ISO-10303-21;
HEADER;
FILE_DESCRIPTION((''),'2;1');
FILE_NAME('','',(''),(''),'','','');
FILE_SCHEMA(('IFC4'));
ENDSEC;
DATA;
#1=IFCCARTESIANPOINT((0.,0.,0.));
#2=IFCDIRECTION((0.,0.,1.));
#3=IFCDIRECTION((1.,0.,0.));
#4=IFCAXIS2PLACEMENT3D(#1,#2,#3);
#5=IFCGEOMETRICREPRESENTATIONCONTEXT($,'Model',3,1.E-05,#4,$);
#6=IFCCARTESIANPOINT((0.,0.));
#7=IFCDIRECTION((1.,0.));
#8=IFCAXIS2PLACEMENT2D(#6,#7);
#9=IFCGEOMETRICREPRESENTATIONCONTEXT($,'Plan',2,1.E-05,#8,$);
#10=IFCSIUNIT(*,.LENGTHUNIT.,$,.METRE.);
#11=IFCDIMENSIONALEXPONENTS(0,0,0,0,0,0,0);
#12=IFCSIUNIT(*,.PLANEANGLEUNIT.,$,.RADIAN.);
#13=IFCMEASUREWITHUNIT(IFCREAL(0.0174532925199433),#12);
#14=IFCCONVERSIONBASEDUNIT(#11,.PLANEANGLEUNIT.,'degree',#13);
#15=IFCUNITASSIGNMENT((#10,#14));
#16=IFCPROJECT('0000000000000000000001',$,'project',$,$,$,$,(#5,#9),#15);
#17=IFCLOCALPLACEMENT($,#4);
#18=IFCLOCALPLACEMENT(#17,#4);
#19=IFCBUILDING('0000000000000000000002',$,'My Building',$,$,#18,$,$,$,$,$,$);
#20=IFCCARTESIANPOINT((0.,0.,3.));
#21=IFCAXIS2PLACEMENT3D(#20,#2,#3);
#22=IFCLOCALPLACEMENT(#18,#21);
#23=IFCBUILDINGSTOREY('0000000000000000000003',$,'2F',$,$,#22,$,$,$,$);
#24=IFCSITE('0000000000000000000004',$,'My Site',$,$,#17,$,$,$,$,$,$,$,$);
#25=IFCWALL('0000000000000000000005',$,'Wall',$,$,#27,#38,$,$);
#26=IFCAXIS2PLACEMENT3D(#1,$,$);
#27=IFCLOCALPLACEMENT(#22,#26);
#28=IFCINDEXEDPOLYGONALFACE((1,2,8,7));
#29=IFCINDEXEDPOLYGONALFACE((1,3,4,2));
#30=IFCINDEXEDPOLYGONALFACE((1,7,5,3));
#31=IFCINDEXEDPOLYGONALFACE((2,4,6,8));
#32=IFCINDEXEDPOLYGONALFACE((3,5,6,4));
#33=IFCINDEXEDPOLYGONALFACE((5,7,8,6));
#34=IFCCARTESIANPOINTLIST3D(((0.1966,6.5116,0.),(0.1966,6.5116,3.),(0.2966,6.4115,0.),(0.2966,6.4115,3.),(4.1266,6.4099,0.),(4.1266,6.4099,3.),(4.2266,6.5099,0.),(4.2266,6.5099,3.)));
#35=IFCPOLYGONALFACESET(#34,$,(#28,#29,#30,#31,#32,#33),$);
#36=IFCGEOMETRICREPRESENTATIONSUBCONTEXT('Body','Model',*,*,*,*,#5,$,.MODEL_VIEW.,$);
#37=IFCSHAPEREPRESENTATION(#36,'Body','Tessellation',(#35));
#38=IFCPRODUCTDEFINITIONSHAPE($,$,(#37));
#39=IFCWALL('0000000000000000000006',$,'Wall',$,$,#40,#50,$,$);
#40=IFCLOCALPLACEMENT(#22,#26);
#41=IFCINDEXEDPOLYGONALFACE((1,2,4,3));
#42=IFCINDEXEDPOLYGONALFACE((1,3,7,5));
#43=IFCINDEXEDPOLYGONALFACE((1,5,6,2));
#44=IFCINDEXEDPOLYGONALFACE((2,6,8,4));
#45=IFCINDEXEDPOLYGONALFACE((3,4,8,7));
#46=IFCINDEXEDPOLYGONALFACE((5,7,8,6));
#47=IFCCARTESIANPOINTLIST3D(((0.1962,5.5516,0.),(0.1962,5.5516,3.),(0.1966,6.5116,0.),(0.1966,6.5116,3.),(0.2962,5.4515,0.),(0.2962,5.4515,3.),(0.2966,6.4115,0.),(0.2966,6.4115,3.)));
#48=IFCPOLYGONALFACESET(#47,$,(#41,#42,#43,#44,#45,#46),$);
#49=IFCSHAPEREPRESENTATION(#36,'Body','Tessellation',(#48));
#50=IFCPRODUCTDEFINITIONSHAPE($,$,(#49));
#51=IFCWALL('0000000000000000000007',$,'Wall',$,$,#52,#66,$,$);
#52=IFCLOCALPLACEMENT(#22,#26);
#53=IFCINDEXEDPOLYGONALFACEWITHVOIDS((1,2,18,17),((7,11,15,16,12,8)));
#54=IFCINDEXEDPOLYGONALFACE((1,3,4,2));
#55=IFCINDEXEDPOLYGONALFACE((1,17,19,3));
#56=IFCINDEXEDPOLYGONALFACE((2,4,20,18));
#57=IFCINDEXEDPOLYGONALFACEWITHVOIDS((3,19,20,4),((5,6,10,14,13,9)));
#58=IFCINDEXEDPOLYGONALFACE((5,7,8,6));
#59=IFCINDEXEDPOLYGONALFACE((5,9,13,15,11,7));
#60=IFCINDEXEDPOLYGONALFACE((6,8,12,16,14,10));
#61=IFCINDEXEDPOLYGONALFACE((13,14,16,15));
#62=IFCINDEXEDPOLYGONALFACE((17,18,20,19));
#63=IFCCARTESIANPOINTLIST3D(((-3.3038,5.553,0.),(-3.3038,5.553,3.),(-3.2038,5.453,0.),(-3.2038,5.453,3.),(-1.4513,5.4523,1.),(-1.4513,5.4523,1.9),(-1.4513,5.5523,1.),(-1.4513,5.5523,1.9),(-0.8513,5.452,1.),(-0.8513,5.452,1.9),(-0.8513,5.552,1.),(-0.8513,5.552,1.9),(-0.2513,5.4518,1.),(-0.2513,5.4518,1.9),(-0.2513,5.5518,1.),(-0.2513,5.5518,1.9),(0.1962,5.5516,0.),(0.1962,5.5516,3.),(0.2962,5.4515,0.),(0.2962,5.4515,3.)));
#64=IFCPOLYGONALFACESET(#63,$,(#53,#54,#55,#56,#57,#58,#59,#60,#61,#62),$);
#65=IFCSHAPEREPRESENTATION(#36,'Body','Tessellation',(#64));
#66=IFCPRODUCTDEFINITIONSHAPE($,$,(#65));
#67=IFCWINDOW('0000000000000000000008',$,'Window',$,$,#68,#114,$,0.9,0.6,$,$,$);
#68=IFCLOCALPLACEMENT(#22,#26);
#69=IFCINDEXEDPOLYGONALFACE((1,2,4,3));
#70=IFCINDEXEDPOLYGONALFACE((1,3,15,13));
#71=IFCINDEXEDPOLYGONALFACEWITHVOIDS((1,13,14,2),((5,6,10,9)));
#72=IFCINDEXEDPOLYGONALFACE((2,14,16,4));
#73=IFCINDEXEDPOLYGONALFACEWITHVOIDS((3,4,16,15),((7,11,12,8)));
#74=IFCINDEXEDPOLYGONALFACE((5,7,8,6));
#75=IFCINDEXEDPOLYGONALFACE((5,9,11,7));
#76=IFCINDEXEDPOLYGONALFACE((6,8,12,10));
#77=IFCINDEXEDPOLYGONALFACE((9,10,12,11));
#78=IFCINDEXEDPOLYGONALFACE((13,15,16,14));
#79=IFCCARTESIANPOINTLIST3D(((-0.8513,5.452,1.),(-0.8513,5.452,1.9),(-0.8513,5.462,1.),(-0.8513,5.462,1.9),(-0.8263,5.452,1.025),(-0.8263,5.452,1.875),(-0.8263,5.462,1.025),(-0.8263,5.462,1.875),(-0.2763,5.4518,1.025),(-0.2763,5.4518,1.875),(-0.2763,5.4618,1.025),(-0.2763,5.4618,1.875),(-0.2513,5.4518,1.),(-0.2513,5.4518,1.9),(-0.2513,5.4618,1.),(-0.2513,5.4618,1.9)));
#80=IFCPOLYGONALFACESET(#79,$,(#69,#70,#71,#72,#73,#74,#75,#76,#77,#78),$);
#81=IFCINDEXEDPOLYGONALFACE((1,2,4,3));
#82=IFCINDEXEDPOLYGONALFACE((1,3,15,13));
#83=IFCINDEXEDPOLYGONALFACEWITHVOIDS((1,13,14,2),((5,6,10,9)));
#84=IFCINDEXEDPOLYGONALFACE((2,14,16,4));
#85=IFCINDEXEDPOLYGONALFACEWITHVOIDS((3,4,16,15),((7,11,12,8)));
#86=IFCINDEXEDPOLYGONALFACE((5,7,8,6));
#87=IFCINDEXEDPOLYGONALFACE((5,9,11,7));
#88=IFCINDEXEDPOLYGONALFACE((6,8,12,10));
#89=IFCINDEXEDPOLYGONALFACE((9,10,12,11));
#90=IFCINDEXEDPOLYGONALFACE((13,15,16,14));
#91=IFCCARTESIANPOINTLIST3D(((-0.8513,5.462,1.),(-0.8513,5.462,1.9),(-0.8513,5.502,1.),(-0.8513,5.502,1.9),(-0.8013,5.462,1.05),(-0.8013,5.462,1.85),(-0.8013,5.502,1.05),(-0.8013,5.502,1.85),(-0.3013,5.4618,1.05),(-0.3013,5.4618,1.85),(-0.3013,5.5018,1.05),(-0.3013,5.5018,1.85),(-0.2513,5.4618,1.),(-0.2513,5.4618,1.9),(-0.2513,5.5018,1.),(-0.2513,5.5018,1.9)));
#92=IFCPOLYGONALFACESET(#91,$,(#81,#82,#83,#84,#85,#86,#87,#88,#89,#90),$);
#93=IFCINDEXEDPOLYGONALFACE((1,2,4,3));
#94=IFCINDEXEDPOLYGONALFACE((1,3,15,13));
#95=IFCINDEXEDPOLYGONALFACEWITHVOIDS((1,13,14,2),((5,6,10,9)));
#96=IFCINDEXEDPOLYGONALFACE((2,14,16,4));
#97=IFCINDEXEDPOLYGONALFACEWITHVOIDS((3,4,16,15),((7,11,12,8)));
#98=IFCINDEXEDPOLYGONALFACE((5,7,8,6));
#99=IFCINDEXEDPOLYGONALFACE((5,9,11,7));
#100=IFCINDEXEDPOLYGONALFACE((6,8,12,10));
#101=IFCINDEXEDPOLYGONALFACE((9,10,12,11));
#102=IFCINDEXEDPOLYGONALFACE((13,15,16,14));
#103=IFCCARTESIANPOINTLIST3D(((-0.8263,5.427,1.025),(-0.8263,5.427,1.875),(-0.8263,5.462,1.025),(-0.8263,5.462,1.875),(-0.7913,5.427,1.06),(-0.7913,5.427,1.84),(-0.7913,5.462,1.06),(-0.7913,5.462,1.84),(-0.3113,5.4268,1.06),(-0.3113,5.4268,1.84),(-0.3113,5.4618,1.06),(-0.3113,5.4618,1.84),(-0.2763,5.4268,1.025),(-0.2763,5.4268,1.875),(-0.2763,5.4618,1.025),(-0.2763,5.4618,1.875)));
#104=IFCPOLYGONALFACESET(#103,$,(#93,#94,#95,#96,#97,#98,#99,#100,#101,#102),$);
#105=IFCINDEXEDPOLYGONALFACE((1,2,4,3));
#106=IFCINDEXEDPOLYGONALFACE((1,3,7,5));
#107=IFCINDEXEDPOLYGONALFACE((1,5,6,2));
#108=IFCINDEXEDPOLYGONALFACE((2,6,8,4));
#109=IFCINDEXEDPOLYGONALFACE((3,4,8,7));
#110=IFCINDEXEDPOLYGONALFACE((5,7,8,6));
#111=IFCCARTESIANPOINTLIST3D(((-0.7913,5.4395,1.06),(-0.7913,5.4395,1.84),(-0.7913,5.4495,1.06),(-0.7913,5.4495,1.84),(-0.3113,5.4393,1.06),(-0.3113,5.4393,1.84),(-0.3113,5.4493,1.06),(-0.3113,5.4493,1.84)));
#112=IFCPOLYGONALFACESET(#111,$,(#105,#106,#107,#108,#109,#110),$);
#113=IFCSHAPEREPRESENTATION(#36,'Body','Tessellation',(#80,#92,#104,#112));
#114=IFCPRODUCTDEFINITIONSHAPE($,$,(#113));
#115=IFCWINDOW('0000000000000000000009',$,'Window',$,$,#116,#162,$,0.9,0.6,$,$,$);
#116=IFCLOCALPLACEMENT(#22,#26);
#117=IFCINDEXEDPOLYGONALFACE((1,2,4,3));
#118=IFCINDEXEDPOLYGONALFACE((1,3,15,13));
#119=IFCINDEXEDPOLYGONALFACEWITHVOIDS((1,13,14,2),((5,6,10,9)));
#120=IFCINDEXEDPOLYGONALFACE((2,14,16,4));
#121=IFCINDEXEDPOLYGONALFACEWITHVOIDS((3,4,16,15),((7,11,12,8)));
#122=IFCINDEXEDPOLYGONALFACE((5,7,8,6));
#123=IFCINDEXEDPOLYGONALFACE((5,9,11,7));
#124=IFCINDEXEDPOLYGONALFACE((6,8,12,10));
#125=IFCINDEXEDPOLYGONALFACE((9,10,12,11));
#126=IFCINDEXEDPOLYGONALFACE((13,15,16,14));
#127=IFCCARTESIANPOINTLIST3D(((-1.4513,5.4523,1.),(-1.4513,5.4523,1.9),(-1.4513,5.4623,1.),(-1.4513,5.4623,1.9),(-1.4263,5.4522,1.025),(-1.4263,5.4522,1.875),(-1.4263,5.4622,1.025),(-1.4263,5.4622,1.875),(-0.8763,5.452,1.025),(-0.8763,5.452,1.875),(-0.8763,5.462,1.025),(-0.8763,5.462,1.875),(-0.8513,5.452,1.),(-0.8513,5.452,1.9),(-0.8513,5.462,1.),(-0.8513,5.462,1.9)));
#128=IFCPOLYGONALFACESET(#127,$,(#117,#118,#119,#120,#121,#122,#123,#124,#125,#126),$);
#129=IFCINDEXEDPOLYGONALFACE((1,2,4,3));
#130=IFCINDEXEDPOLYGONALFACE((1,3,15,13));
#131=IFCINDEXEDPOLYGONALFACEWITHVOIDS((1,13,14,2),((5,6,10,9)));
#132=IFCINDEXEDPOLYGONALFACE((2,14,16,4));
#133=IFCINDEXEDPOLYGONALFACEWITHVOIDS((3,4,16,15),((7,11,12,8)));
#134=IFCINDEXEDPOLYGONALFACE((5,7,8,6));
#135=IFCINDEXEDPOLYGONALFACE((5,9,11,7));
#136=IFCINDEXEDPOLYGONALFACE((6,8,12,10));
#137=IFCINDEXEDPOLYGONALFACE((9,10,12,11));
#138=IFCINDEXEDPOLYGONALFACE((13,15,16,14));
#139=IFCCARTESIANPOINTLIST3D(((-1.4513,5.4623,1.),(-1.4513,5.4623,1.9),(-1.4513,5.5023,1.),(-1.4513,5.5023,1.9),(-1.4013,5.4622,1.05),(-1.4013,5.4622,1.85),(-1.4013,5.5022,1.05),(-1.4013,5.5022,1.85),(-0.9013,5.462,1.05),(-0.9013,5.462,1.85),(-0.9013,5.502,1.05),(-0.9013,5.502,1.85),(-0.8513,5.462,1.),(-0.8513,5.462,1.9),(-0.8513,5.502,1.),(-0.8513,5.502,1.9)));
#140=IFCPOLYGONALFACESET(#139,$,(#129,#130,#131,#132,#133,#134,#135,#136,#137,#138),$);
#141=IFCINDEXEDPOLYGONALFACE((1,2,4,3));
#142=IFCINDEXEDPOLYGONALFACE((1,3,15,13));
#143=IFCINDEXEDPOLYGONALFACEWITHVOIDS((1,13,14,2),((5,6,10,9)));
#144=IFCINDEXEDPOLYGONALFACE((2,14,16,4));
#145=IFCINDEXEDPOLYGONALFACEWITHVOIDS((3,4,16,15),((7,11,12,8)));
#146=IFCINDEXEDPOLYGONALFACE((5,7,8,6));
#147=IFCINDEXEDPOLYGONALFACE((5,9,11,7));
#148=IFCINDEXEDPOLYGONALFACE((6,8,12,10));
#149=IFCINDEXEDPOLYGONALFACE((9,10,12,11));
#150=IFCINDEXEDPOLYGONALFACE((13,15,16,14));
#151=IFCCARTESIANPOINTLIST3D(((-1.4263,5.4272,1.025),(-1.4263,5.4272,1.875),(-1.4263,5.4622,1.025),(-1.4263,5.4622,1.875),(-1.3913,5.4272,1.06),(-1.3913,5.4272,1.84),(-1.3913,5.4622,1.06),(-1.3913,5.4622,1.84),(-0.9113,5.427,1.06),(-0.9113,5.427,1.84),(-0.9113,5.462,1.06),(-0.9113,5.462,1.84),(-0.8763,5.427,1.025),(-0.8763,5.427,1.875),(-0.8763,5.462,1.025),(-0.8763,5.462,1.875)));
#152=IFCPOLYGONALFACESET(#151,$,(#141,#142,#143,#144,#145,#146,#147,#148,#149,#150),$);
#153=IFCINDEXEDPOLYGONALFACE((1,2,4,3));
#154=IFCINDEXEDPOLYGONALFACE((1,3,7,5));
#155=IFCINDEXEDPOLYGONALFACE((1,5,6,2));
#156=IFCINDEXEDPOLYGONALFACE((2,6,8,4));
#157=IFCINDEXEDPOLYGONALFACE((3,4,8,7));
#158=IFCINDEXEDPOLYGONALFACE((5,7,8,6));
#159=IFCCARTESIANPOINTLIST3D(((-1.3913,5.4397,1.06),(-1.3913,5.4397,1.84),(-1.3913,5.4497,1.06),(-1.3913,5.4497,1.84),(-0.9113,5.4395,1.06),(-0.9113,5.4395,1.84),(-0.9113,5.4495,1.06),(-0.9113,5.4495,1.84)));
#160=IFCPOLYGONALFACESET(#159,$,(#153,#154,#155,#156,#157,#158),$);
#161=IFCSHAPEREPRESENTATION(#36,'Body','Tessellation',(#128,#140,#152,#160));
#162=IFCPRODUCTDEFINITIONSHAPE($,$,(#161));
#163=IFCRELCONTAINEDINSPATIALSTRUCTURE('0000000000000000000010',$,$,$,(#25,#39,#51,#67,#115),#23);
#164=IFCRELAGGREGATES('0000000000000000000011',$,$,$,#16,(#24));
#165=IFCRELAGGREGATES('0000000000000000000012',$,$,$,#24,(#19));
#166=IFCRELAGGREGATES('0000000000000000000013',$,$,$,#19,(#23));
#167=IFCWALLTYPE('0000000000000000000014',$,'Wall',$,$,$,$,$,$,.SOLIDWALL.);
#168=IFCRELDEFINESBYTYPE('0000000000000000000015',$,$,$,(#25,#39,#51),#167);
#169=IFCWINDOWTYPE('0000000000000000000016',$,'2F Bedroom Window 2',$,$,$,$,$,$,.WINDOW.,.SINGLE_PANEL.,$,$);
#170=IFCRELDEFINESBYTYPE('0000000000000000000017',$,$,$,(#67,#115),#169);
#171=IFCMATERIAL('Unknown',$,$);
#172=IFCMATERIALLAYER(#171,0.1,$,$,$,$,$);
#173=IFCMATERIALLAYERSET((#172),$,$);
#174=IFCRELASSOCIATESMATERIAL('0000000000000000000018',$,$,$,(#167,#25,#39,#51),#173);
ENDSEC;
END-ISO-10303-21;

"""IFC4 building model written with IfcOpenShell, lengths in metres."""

from ifc_helpers import new_model, entity, si_unit, converted_unit, frame, origin_with_axes, origin_2d_with_axis, place, context, subcontext, project, spatial, line, indexed_curve, outline, extrude, shape, source, transform, mapped, material, layer, layer_set, layer_usage, type_object, type_shapes, element, fill, save


model = new_model("IFC4")

# Units and contexts
model_context = context("Model", 3, precision=1e-05, world=origin_with_axes())
plan_context = context("Plan", 2, precision=1e-05, world=origin_2d_with_axis())
body_context_1 = subcontext(model_context, "Body", "Model", "MODEL_VIEW")
body_context_2 = subcontext(plan_context, "Body", "Plan", "PLAN_VIEW")
ifc_project = project(units=[si_unit("LENGTHUNIT", "METRE"), converted_unit("PLANEANGLEUNIT", "degree", entity("IfcReal", 0.0174532925199433), si_unit("PLANEANGLEUNIT", "RADIAN"), dimensions=[0, 0, 0, 0, 0, 0, 0])], contexts=[model_context, plan_context])

# Site, building, storey
site_placement = place(None, origin_with_axes())
site = spatial("IfcSite", under=ifc_project, at=site_placement, Name="My Site")
building_placement = place(site_placement, origin_with_axes())
building = spatial("IfcBuilding", under=site, at=building_placement, Name="My Building")
storey_placement = place(building_placement, frame((0.0, 0.0, 3.0), z_axis=(0.0, 0.0, 1.0), x_axis=(1.0, 0.0, 0.0)))
storey = spatial("IfcBuildingStorey", under=building, at=storey_placement, Name="2F")

# Shared definitions
ifc_material = material(Name="Unknown")

# Walls
ifc_layer = layer(ifc_material, 0.1)
ifc_layer_set = layer_set([ifc_layer])
ifc_layer_usage_1 = layer_usage(ifc_layer_set, "AXIS2", "POSITIVE", 0.0)
wall_type = type_object("IfcWallType", Name="Wall", PredefinedType="SOLIDWALL", material=ifc_layer_set)
wall_1_placement = place(storey_placement, frame((4.2266, 6.5099, 0.0), z_axis=(0.0, 0.0, 1.0), x_axis=(-1.0, 0.000415, 0.0)))
element("IfcWall", 1, at=wall_1_placement, inside=storey, type_object=wall_type, material=ifc_layer_usage_1, Name="Wall", context=body_context_1, shape_type="SweptSolid", body=[
    extrude(outline(indexed_curve([(0.0, 0.0), (0.1, 0.1), (3.93, 0.1), (4.03, 0.0)], segments=[line(1, 2, 3, 4, 1)])), origin_with_axes(), (0.0, 0.0, 1.0), 3.0),
])
ifc_layer_usage_2 = layer_usage(ifc_layer_set, "AXIS2", "POSITIVE", 0.0)
wall_2_placement = place(storey_placement, frame((0.1966, 6.5116, 0.0), z_axis=(0.0, 0.0, 1.0), x_axis=(-0.000415, -1.0, 0.0)))
element("IfcWall", 2, at=wall_2_placement, inside=storey, type_object=wall_type, material=ifc_layer_usage_2, Name="Wall", context=body_context_1, shape_type="SweptSolid", body=[
    extrude(outline(indexed_curve([(0.0, 0.0), (0.1, 0.1), (1.06, 0.1), (0.96, 0.0)], segments=[line(1, 2, 3, 4, 1)])), origin_with_axes(), (0.0, 0.0, 1.0), 3.0),
])

# Wall, openings, windows
ifc_layer_usage_3 = layer_usage(ifc_layer_set, "AXIS2", "POSITIVE", 0.0)
wall_3_placement = place(storey_placement, frame((0.1962, 5.5516, 0.0), z_axis=(0.0, 0.0, 1.0), x_axis=(-1.0, 0.000416, 0.0)))
wall_3 = element("IfcWall", 3, at=wall_3_placement, inside=storey, type_object=wall_type, material=ifc_layer_usage_3, Name="Wall", context=body_context_1, shape_type="SweptSolid", body=[
    extrude(outline(indexed_curve([(0.0, 0.0), (-0.1, 0.1), (3.4, 0.1), (3.5, 0.0)], segments=[line(1, 2, 3, 4, 1)])), origin_with_axes(), (0.0, 0.0, 1.0), 3.0),
])
shared_shape_1 = source(origin_with_axes(), body_context_1, "Body", "SweptSolid", [
    extrude(outline(indexed_curve([(0.0, 0.0), (0.6, 0.0), (0.6, 0.9), (0.0, 0.9)], segments=[line(1, 2, 3, 4, 1)])), frame((0.0, -0.6, 0.0), z_axis=(0.0, -1.0, 0.0), x_axis=(1.0, 0.0, 0.0)), (0.0, 0.0, -1.0), 1.2),
])
opening_1_placement = place(wall_3_placement, frame((0.4475, 0.0, 1.0), z_axis=(0.0, 0.0, 1.0), x_axis=(1.0, 0.0, 0.0)))
opening_1 = element("IfcOpeningElement", 4, at=opening_1_placement, cuts=wall_3, PredefinedType="OPENING", context=body_context_1, shape_type="MappedRepresentation", body=[
    mapped(shared_shape_1, transform((0.0, 0.0, 0.0), x_axis=(1.0, 0.0, 0.0), y_axis=(0.0, 1.0, 0.0), z_axis=(0.0, 0.0, 1.0), scale=1.0)),
])
opening_2_placement = place(wall_3_placement, frame((1.0475, 0.0, 1.0), z_axis=(0.0, 0.0, 1.0), x_axis=(1.0, 0.0, 0.0)))
opening_2 = element("IfcOpeningElement", 5, at=opening_2_placement, cuts=wall_3, PredefinedType="OPENING", context=body_context_1, shape_type="MappedRepresentation", body=[
    mapped(shared_shape_1, transform((0.0, 0.0, 0.0), x_axis=(1.0, 0.0, 0.0), y_axis=(0.0, 1.0, 0.0), z_axis=(0.0, 0.0, 1.0), scale=1.0)),
])
window_type_1 = type_object("IfcWindowType", Name="2F Bedroom Window 2", PartitioningType="SINGLE_PANEL", PredefinedType="WINDOW")
shared_shape_2 = source(origin_with_axes(), body_context_1, "Body", "SweptSolid", [
    extrude(outline(indexed_curve([(0.0, 0.0), (0.6, 0.0), (0.6, 0.9), (0.0, 0.9)], segments=[line(1, 2, 3, 4, 1)]), holes=[indexed_curve([(0.025, 0.025), (0.575, 0.025), (0.575, 0.875), (0.025, 0.875)], segments=[line(1, 2, 3, 4, 1)])]), frame((0.0, 0.09, 0.0), z_axis=(0.0, -1.0, 0.0), x_axis=(1.0, 0.0, 0.0)), (0.0, 0.0, -1.0), 0.01),
    extrude(outline(indexed_curve([(0.0, 0.0), (0.6, 0.0), (0.6, 0.9), (0.0, 0.9)], segments=[line(1, 2, 3, 4, 1)]), holes=[indexed_curve([(0.05, 0.05), (0.55, 0.05), (0.55, 0.85), (0.05, 0.85)], segments=[line(1, 2, 3, 4, 1)])]), frame((0.0, 0.05, 0.0), z_axis=(0.0, -1.0, 0.0), x_axis=(1.0, 0.0, 0.0)), (0.0, 0.0, -1.0), 0.04),
    extrude(outline(indexed_curve([(0.0, 0.0), (0.55, 0.0), (0.55, 0.85), (0.0, 0.85)], segments=[line(1, 2, 3, 4, 1)]), holes=[indexed_curve([(0.035, 0.035), (0.515, 0.035), (0.515, 0.815), (0.035, 0.815)], segments=[line(1, 2, 3, 4, 1)])]), frame((0.025, 0.09, 0.025), z_axis=(0.0, -1.0, 0.0), x_axis=(1.0, 0.0, 0.0)), (0.0, 0.0, -1.0), 0.035),
    extrude(outline(indexed_curve([(0.035, 0.035), (0.515, 0.035), (0.515, 0.815), (0.035, 0.815)], segments=[line(1, 2, 3, 4, 1)])), frame((0.025, 0.1025, 0.025), z_axis=(0.0, -1.0, 0.0), x_axis=(1.0, 0.0, 0.0)), (0.0, 0.0, -1.0), 0.01),
])
shared_shape_3 = source(origin_with_axes(), body_context_2, "Body", "Curve2D", [
    entity("IfcIndexedPolyCurve", entity("IfcCartesianPointList2D", [[0.05, 0.05], [0.55, 0.05]])),
    entity("IfcIndexedPolyCurve", entity("IfcCartesianPointList2D", [[0.0, 0.1], [0.025, 0.1], [0.025, 0.09], [0.05, 0.09], [0.05, 0.05], [0.0, 0.05]]), [entity("IfcLineIndex", [1, 2, 3, 4, 5, 6, 1])]),
    entity("IfcIndexedPolyCurve", entity("IfcCartesianPointList2D", [[0.6, 0.1], [0.575, 0.1], [0.575, 0.09], [0.55, 0.09], [0.55, 0.05], [0.6, 0.05]]), [entity("IfcLineIndex", [1, 2, 3, 4, 5, 6, 1])]),
    entity("IfcIndexedPolyCurve", entity("IfcCartesianPointList2D", [[0.025, 0.09], [0.06, 0.09], [0.06, 0.125], [0.025, 0.125]]), [entity("IfcLineIndex", [1, 2, 3, 4, 1])]),
    entity("IfcIndexedPolyCurve", entity("IfcCartesianPointList2D", [[0.575, 0.09], [0.54, 0.09], [0.54, 0.125], [0.575, 0.125]]), [entity("IfcLineIndex", [1, 2, 3, 4, 1])]),
    entity("IfcIndexedPolyCurve", entity("IfcCartesianPointList2D", [[0.06, 0.09], [0.54, 0.09]])),
    entity("IfcIndexedPolyCurve", entity("IfcCartesianPointList2D", [[0.06, 0.125], [0.54, 0.125]])),
    entity("IfcIndexedPolyCurve", entity("IfcCartesianPointList2D", [[0.06, 0.1075], [0.54, 0.1075]])),
])
type_shapes(window_type_1, [shared_shape_2, shared_shape_3])
window_1_placement = place(opening_1_placement, frame((0.0, 0.0, 0.0), z_axis=(0.0, 0.0, 1.0), x_axis=(1.0, 0.0, 0.0)))
window_1 = element("IfcWindow", 6, at=window_1_placement, inside=storey, type_object=window_type_1, Name="Window", OverallHeight=0.9, OverallWidth=0.6, shapes=[
    shape(body_context_1, "Body", "MappedRepresentation", [mapped(shared_shape_2, transform((0.0, 0.0, 0.0), x_axis=(1.0, 0.0, 0.0), y_axis=(0.0, 1.0, 0.0), z_axis=(0.0, 0.0, 1.0), scale=1.0))]),
    shape(body_context_2, "Body", "MappedRepresentation", [mapped(shared_shape_3, transform((0.0, 0.0, 0.0), x_axis=(1.0, 0.0, 0.0), y_axis=(0.0, 1.0, 0.0), z_axis=(0.0, 0.0, 1.0), scale=1.0))]),
])
fill(opening_1, window_1)
window_2_placement = place(opening_2_placement, origin_with_axes())
window_2 = element("IfcWindow", 7, at=window_2_placement, inside=storey, type_object=window_type_1, Name="Window", OverallHeight=0.9, OverallWidth=0.6, shapes=[
    shape(body_context_1, "Body", "MappedRepresentation", [mapped(shared_shape_2, transform((0.0, 0.0, 0.0), x_axis=(1.0, 0.0, 0.0), y_axis=(0.0, 1.0, 0.0), z_axis=(0.0, 0.0, 1.0), scale=1.0))]),
    shape(body_context_2, "Body", "MappedRepresentation", [mapped(shared_shape_3, transform((0.0, 0.0, 0.0), x_axis=(1.0, 0.0, 0.0), y_axis=(0.0, 1.0, 0.0), z_axis=(0.0, 0.0, 1.0), scale=1.0))]),
])
fill(opening_2, window_2)

save(model, "model.ifc")
